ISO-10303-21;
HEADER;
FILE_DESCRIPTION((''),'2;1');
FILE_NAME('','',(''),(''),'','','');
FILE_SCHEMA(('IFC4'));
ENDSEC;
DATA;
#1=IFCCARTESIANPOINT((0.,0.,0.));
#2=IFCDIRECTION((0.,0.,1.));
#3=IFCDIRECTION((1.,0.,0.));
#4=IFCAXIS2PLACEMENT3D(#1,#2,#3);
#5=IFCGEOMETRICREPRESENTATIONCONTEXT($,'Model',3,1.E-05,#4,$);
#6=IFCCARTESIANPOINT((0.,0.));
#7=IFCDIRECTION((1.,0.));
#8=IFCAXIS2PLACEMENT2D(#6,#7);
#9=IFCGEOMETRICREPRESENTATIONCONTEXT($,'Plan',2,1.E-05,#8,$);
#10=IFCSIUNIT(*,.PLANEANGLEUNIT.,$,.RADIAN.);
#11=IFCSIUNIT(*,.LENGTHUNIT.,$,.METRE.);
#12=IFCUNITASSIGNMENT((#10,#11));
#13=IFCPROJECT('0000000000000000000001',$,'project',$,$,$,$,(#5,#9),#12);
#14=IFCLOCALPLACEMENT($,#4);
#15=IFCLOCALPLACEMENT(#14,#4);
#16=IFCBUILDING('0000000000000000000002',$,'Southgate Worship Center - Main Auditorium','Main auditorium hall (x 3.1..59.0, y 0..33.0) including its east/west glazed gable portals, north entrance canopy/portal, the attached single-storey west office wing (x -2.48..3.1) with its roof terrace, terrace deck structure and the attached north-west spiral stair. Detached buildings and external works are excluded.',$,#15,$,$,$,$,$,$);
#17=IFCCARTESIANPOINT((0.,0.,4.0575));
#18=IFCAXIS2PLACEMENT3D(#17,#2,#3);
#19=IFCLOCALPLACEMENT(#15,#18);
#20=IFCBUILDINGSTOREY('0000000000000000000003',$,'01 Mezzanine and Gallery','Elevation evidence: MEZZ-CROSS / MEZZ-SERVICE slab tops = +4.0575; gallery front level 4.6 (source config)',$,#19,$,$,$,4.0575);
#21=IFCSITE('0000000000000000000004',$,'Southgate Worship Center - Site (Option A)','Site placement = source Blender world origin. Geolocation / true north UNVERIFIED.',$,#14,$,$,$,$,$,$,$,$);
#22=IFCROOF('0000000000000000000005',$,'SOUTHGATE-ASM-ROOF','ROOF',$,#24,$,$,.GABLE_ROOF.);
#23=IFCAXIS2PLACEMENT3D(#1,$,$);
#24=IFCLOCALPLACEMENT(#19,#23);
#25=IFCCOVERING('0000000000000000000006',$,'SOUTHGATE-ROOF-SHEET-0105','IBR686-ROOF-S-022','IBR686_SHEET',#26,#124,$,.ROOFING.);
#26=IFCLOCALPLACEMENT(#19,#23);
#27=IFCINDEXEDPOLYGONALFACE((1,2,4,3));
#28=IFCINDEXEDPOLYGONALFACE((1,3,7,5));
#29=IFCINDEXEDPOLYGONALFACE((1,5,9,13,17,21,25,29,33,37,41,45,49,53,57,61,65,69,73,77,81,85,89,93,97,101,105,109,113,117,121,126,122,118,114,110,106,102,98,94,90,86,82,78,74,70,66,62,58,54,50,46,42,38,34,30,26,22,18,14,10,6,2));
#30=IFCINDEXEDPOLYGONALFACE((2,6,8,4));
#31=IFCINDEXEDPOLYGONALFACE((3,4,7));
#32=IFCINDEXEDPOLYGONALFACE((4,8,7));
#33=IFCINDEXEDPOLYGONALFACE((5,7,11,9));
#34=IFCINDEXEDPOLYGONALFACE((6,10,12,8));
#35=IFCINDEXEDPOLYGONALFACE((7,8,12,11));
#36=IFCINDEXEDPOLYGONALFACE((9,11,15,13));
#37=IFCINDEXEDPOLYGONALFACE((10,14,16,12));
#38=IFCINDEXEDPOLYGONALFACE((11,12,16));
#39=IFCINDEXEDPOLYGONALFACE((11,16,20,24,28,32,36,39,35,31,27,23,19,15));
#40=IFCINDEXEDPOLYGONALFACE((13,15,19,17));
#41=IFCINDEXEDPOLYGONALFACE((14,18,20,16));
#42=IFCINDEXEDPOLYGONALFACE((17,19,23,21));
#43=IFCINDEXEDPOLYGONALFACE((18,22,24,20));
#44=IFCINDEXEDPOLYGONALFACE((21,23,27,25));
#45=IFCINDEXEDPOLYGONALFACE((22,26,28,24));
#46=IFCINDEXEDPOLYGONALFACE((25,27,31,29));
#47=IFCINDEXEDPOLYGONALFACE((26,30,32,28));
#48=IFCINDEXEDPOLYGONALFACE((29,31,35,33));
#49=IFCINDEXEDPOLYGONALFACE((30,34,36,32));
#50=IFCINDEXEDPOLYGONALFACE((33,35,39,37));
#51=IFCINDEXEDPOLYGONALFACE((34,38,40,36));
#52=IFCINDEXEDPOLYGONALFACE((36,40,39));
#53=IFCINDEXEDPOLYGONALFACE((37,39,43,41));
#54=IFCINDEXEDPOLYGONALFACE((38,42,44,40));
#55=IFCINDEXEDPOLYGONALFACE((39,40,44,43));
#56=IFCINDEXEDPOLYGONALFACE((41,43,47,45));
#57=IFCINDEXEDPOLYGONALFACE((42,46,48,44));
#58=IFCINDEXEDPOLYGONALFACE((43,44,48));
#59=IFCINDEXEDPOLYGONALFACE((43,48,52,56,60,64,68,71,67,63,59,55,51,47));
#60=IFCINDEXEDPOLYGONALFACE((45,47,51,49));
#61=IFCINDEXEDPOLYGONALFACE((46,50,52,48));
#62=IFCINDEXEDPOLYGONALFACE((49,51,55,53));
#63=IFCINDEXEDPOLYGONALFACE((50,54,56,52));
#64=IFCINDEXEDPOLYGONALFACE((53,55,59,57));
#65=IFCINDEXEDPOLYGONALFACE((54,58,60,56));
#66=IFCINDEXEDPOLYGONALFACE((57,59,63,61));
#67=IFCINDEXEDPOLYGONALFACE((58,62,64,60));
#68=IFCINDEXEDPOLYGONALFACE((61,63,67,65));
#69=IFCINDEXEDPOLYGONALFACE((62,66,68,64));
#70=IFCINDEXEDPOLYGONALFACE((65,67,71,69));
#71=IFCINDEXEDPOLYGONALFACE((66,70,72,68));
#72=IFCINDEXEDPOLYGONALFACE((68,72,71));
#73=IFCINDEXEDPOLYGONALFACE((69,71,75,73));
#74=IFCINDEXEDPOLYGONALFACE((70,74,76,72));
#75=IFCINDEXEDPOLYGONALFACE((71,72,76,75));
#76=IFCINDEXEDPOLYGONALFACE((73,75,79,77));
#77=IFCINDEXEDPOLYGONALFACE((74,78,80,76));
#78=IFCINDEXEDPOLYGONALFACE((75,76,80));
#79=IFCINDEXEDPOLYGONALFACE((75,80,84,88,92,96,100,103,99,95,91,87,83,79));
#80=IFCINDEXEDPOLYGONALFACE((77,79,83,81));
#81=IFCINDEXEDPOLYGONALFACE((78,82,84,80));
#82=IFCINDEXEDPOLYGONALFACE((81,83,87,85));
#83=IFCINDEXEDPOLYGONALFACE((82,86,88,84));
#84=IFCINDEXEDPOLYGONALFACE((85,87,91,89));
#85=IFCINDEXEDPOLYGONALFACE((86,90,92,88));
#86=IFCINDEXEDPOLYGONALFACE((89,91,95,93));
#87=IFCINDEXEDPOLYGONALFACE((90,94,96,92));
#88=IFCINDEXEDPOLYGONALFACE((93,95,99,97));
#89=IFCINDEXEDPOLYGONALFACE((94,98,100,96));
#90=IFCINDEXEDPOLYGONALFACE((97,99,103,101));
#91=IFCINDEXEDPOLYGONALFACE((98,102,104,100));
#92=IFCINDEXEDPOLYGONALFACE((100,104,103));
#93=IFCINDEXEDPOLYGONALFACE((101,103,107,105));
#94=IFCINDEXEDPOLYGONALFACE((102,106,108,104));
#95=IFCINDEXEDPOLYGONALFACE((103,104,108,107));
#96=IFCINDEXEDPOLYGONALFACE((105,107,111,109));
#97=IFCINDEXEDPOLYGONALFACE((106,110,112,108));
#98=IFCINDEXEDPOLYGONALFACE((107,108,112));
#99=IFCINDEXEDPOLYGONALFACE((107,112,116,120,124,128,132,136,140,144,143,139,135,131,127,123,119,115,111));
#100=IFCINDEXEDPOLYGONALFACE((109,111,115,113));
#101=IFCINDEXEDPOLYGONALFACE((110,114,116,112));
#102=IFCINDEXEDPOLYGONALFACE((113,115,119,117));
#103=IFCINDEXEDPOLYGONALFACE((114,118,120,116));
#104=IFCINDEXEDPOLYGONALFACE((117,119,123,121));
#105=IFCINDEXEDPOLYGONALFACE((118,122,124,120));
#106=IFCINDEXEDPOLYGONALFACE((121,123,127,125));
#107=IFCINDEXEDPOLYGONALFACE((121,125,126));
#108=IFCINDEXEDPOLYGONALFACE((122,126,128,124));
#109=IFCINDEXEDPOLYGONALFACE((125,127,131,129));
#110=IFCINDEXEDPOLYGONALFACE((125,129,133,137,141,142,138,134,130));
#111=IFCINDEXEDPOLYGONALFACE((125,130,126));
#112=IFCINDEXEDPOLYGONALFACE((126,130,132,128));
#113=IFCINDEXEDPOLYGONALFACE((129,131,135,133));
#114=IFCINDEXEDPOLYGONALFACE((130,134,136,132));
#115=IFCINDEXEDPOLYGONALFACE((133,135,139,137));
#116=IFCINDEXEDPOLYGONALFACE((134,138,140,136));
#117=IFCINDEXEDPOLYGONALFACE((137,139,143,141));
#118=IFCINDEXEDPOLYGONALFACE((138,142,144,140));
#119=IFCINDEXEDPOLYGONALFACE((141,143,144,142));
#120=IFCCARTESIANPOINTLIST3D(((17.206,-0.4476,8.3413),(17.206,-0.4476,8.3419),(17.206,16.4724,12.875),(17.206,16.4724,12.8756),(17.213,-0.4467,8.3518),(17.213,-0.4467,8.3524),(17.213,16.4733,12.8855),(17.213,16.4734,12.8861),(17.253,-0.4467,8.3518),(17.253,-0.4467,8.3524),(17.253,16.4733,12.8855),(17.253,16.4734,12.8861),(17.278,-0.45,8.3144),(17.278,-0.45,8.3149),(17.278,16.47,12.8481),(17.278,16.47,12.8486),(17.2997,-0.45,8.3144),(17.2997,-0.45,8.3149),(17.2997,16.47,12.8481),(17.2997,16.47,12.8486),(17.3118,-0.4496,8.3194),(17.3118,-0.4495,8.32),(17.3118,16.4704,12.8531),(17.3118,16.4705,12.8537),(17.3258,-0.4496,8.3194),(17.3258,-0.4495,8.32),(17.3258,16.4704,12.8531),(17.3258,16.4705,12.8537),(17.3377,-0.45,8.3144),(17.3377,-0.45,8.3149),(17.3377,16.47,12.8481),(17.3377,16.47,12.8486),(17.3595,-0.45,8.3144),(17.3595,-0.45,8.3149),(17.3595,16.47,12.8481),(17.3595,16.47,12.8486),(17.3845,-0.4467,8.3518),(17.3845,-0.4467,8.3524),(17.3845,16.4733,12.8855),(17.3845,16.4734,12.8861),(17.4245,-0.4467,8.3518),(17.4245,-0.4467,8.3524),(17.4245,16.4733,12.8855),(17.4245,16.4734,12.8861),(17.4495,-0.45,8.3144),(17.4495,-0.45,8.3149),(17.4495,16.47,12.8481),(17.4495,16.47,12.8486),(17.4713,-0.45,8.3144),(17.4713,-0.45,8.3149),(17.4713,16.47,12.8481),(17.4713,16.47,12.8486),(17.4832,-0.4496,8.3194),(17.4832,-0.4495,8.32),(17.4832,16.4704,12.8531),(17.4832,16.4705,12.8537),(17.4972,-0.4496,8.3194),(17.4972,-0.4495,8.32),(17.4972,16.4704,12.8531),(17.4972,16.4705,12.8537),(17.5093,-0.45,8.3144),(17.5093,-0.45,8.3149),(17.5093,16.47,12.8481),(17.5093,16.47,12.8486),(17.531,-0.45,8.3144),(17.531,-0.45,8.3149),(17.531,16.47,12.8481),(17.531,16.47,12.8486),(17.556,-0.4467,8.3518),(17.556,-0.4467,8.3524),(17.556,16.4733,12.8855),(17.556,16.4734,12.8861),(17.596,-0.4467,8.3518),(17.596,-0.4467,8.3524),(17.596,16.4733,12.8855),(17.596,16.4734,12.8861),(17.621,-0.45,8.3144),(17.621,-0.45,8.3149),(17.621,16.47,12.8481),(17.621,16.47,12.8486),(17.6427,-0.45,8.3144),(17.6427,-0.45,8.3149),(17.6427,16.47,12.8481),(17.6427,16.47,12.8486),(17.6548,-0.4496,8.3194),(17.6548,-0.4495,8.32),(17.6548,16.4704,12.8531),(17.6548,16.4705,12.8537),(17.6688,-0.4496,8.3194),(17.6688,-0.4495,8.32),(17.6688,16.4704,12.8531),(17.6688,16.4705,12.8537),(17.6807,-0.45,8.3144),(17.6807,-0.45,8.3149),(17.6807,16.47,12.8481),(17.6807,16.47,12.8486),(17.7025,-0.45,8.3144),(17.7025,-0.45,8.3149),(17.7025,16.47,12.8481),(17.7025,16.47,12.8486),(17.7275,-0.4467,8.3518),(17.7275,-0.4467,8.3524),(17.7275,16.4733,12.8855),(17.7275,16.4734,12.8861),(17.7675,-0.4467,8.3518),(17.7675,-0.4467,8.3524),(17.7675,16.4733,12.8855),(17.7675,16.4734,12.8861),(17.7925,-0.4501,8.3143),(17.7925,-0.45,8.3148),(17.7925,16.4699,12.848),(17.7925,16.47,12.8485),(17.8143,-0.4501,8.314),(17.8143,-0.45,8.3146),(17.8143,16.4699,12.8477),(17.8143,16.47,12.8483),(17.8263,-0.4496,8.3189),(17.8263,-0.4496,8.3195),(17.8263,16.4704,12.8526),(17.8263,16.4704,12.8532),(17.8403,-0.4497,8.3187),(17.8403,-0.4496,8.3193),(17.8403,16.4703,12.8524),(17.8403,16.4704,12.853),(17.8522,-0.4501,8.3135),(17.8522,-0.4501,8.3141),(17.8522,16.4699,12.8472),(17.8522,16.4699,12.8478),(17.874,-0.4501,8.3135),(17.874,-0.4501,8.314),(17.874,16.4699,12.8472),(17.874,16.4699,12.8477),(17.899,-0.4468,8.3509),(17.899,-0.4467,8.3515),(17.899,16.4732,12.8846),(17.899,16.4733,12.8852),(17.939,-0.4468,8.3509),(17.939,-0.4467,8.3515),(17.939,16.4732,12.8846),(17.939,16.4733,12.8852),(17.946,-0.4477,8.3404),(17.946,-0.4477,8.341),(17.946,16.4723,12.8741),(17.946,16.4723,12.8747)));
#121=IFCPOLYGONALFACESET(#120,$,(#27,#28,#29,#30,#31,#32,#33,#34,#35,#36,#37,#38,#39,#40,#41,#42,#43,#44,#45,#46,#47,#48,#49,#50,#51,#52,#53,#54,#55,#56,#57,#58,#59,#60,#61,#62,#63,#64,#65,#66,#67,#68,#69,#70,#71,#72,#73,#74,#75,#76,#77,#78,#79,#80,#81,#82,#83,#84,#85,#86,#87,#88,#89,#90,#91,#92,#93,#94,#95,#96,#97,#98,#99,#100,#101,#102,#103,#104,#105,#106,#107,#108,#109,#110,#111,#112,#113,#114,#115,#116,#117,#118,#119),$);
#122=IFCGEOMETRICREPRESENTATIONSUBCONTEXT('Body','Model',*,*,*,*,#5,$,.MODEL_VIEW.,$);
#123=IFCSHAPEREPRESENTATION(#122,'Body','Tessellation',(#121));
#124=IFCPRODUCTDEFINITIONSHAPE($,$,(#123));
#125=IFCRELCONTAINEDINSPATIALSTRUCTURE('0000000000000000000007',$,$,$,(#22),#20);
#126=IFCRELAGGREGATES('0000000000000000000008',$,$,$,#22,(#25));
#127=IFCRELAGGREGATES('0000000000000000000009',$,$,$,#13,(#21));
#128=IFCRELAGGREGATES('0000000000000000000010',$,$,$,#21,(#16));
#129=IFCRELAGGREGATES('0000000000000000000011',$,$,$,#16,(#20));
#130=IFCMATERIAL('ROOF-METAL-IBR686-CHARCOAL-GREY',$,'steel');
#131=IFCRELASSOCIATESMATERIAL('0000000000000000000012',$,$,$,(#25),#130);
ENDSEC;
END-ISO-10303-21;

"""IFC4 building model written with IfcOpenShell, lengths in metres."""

from ifc_helpers import new_model, si_unit, frame, origin_with_axes, origin_2d_with_axis, place, context, subcontext, project, spatial, indexed_curve, outline, extrude, clip, halfspace, material, element, aggregate, save


model = new_model("IFC4")

# Units and contexts
model_context = context("Model", 3, precision=1e-05, world=origin_with_axes())
plan_context = context("Plan", 2, precision=1e-05, world=origin_2d_with_axis())
body_context = subcontext(model_context, "Body", "Model", "MODEL_VIEW")
ifc_project = project(units=[si_unit("PLANEANGLEUNIT", "RADIAN"), si_unit("LENGTHUNIT", "METRE")], contexts=[model_context, plan_context])

# Site, building, storey
site_placement = place(None, origin_with_axes())
site = spatial("IfcSite", under=ifc_project, at=site_placement, Name="Southgate Worship Center - Site (Option A)", Description="Site placement = source Blender world origin. Geolocation / true north UNVERIFIED.")
building_placement = place(site_placement, origin_with_axes())
building = spatial("IfcBuilding", under=site, at=building_placement, Name="Southgate Worship Center - Main Auditorium", Description="Main auditorium hall (x 3.1..59.0, y 0..33.0) including its east/west glazed gable portals, north entrance canopy/portal, the attached single-storey west office wing (x -2.48..3.1) with its roof terrace, terrace deck structure and the attached north-west spiral stair. Detached buildings and external works are excluded.")
storey_placement = place(building_placement, frame((0.0, 0.0, 4.0575), z_axis=(0.0, 0.0, 1.0), x_axis=(1.0, 0.0, 0.0)))
storey = spatial("IfcBuildingStorey", under=building, at=storey_placement, Name="01 Mezzanine and Gallery", Description="Elevation evidence: MEZZ-CROSS / MEZZ-SERVICE slab tops = +4.0575; gallery front level 4.6 (source config)", Elevation=4.0575)

# Roof, covering
roof_placement = place(storey_placement, origin_with_axes())
roof = element("IfcRoof", 1, at=roof_placement, inside=storey, Name="SOUTHGATE-ASM-ROOF", Description="ROOF", PredefinedType="GABLE_ROOF")
ifc_material_1 = material(Name="ROOF-METAL-IBR686-CHARCOAL-GREY", Category="steel")
covering_1_placement = place(roof_placement, frame((17.206, -0.4501, 8.3135), z_axis=(0.0, 0.0, 1.0), x_axis=(1.0, 0.0, 0.0)))
covering_1 = element("IfcCovering", 2, at=covering_1_placement, material=ifc_material_1, Name="SOUTHGATE-ROOF-SHEET-0105", Description="IBR686-ROOF-S-022", ObjectType="IBR686_SHEET", PredefinedType="ROOFING", context=body_context, shape_type="Clipping", body=[
    clip(clip(extrude(outline(indexed_curve([(0.0, 0.0), (0.025, 0.0353), (0.065, 0.0353), (0.072, 0.0254), (0.072, 0.0259), (0.065, 0.0358), (0.025, 0.0358), (0.0, 0.0005), (-0.0217, 0.0005), (-0.0338, 0.0053), (-0.0478, 0.0053), (-0.0597, 0.0005), (-0.0815, 0.0005), (-0.1065, 0.0358), (-0.1465, 0.0358), (-0.1715, 0.0005), (-0.1933, 0.0005), (-0.2052, 0.0053), (-0.2192, 0.0053), (-0.2313, 0.0005), (-0.253, 0.0005), (-0.278, 0.0358), (-0.318, 0.0358), (-0.343, 0.0005), (-0.3647, 0.0005), (-0.3768, 0.0053), (-0.3908, 0.0053), (-0.4028, 0.0005), (-0.4245, 0.0005), (-0.4495, 0.0358), (-0.4895, 0.0358), (-0.5145, 0.0004), (-0.5363, 0.0002), (-0.5483, 0.0048), (-0.5623, 0.0046), (-0.5742, -0.0003), (-0.596, -0.0004), (-0.621, 0.0349), (-0.661, 0.0349), (-0.668, 0.0251), (-0.668, 0.0246), (-0.661, 0.0344), (-0.621, 0.0344), (-0.596, -0.0009), (-0.5742, -0.0008), (-0.5623, 0.0041), (-0.5483, 0.0043), (-0.5363, -0.0003), (-0.5145, -0.0001), (-0.4895, 0.0353), (-0.4495, 0.0353), (-0.4245, 0.0), (-0.4028, 0.0), (-0.3908, 0.0048), (-0.3768, 0.0048), (-0.3647, 0.0), (-0.343, 0.0), (-0.318, 0.0353), (-0.278, 0.0353), (-0.253, 0.0), (-0.2313, 0.0), (-0.2192, 0.0048), (-0.2052, 0.0048), (-0.1933, 0.0), (-0.1715, 0.0), (-0.1465, 0.0353), (-0.1065, 0.0353), (-0.0815, 0.0), (-0.0597, 0.0), (-0.0478, 0.0048), (-0.0338, 0.0048), (-0.0217, 0.0), (0.0, 0.0)], self_intersect=False)), frame((0.072, -0.0003, 0.0008), z_axis=(0.0, 0.965926, 0.258819), x_axis=(-1.0, 0.0, 0.0)), (0.0, 0.0, 1.0), 17.5303), halfspace(frame((0.37, 0.0012, 0.014), z_axis=(0.0, -0.996022, 0.089113), x_axis=(1.0, 0.0, 0.0)), False)), halfspace(frame((0.37, 16.9212, 4.5477), z_axis=(0.0, 0.996021, -0.089119), x_axis=(-1.0, 0.0, 0.0)), False)),
])
aggregate(roof, [covering_1])

save(model, "model.ifc")
